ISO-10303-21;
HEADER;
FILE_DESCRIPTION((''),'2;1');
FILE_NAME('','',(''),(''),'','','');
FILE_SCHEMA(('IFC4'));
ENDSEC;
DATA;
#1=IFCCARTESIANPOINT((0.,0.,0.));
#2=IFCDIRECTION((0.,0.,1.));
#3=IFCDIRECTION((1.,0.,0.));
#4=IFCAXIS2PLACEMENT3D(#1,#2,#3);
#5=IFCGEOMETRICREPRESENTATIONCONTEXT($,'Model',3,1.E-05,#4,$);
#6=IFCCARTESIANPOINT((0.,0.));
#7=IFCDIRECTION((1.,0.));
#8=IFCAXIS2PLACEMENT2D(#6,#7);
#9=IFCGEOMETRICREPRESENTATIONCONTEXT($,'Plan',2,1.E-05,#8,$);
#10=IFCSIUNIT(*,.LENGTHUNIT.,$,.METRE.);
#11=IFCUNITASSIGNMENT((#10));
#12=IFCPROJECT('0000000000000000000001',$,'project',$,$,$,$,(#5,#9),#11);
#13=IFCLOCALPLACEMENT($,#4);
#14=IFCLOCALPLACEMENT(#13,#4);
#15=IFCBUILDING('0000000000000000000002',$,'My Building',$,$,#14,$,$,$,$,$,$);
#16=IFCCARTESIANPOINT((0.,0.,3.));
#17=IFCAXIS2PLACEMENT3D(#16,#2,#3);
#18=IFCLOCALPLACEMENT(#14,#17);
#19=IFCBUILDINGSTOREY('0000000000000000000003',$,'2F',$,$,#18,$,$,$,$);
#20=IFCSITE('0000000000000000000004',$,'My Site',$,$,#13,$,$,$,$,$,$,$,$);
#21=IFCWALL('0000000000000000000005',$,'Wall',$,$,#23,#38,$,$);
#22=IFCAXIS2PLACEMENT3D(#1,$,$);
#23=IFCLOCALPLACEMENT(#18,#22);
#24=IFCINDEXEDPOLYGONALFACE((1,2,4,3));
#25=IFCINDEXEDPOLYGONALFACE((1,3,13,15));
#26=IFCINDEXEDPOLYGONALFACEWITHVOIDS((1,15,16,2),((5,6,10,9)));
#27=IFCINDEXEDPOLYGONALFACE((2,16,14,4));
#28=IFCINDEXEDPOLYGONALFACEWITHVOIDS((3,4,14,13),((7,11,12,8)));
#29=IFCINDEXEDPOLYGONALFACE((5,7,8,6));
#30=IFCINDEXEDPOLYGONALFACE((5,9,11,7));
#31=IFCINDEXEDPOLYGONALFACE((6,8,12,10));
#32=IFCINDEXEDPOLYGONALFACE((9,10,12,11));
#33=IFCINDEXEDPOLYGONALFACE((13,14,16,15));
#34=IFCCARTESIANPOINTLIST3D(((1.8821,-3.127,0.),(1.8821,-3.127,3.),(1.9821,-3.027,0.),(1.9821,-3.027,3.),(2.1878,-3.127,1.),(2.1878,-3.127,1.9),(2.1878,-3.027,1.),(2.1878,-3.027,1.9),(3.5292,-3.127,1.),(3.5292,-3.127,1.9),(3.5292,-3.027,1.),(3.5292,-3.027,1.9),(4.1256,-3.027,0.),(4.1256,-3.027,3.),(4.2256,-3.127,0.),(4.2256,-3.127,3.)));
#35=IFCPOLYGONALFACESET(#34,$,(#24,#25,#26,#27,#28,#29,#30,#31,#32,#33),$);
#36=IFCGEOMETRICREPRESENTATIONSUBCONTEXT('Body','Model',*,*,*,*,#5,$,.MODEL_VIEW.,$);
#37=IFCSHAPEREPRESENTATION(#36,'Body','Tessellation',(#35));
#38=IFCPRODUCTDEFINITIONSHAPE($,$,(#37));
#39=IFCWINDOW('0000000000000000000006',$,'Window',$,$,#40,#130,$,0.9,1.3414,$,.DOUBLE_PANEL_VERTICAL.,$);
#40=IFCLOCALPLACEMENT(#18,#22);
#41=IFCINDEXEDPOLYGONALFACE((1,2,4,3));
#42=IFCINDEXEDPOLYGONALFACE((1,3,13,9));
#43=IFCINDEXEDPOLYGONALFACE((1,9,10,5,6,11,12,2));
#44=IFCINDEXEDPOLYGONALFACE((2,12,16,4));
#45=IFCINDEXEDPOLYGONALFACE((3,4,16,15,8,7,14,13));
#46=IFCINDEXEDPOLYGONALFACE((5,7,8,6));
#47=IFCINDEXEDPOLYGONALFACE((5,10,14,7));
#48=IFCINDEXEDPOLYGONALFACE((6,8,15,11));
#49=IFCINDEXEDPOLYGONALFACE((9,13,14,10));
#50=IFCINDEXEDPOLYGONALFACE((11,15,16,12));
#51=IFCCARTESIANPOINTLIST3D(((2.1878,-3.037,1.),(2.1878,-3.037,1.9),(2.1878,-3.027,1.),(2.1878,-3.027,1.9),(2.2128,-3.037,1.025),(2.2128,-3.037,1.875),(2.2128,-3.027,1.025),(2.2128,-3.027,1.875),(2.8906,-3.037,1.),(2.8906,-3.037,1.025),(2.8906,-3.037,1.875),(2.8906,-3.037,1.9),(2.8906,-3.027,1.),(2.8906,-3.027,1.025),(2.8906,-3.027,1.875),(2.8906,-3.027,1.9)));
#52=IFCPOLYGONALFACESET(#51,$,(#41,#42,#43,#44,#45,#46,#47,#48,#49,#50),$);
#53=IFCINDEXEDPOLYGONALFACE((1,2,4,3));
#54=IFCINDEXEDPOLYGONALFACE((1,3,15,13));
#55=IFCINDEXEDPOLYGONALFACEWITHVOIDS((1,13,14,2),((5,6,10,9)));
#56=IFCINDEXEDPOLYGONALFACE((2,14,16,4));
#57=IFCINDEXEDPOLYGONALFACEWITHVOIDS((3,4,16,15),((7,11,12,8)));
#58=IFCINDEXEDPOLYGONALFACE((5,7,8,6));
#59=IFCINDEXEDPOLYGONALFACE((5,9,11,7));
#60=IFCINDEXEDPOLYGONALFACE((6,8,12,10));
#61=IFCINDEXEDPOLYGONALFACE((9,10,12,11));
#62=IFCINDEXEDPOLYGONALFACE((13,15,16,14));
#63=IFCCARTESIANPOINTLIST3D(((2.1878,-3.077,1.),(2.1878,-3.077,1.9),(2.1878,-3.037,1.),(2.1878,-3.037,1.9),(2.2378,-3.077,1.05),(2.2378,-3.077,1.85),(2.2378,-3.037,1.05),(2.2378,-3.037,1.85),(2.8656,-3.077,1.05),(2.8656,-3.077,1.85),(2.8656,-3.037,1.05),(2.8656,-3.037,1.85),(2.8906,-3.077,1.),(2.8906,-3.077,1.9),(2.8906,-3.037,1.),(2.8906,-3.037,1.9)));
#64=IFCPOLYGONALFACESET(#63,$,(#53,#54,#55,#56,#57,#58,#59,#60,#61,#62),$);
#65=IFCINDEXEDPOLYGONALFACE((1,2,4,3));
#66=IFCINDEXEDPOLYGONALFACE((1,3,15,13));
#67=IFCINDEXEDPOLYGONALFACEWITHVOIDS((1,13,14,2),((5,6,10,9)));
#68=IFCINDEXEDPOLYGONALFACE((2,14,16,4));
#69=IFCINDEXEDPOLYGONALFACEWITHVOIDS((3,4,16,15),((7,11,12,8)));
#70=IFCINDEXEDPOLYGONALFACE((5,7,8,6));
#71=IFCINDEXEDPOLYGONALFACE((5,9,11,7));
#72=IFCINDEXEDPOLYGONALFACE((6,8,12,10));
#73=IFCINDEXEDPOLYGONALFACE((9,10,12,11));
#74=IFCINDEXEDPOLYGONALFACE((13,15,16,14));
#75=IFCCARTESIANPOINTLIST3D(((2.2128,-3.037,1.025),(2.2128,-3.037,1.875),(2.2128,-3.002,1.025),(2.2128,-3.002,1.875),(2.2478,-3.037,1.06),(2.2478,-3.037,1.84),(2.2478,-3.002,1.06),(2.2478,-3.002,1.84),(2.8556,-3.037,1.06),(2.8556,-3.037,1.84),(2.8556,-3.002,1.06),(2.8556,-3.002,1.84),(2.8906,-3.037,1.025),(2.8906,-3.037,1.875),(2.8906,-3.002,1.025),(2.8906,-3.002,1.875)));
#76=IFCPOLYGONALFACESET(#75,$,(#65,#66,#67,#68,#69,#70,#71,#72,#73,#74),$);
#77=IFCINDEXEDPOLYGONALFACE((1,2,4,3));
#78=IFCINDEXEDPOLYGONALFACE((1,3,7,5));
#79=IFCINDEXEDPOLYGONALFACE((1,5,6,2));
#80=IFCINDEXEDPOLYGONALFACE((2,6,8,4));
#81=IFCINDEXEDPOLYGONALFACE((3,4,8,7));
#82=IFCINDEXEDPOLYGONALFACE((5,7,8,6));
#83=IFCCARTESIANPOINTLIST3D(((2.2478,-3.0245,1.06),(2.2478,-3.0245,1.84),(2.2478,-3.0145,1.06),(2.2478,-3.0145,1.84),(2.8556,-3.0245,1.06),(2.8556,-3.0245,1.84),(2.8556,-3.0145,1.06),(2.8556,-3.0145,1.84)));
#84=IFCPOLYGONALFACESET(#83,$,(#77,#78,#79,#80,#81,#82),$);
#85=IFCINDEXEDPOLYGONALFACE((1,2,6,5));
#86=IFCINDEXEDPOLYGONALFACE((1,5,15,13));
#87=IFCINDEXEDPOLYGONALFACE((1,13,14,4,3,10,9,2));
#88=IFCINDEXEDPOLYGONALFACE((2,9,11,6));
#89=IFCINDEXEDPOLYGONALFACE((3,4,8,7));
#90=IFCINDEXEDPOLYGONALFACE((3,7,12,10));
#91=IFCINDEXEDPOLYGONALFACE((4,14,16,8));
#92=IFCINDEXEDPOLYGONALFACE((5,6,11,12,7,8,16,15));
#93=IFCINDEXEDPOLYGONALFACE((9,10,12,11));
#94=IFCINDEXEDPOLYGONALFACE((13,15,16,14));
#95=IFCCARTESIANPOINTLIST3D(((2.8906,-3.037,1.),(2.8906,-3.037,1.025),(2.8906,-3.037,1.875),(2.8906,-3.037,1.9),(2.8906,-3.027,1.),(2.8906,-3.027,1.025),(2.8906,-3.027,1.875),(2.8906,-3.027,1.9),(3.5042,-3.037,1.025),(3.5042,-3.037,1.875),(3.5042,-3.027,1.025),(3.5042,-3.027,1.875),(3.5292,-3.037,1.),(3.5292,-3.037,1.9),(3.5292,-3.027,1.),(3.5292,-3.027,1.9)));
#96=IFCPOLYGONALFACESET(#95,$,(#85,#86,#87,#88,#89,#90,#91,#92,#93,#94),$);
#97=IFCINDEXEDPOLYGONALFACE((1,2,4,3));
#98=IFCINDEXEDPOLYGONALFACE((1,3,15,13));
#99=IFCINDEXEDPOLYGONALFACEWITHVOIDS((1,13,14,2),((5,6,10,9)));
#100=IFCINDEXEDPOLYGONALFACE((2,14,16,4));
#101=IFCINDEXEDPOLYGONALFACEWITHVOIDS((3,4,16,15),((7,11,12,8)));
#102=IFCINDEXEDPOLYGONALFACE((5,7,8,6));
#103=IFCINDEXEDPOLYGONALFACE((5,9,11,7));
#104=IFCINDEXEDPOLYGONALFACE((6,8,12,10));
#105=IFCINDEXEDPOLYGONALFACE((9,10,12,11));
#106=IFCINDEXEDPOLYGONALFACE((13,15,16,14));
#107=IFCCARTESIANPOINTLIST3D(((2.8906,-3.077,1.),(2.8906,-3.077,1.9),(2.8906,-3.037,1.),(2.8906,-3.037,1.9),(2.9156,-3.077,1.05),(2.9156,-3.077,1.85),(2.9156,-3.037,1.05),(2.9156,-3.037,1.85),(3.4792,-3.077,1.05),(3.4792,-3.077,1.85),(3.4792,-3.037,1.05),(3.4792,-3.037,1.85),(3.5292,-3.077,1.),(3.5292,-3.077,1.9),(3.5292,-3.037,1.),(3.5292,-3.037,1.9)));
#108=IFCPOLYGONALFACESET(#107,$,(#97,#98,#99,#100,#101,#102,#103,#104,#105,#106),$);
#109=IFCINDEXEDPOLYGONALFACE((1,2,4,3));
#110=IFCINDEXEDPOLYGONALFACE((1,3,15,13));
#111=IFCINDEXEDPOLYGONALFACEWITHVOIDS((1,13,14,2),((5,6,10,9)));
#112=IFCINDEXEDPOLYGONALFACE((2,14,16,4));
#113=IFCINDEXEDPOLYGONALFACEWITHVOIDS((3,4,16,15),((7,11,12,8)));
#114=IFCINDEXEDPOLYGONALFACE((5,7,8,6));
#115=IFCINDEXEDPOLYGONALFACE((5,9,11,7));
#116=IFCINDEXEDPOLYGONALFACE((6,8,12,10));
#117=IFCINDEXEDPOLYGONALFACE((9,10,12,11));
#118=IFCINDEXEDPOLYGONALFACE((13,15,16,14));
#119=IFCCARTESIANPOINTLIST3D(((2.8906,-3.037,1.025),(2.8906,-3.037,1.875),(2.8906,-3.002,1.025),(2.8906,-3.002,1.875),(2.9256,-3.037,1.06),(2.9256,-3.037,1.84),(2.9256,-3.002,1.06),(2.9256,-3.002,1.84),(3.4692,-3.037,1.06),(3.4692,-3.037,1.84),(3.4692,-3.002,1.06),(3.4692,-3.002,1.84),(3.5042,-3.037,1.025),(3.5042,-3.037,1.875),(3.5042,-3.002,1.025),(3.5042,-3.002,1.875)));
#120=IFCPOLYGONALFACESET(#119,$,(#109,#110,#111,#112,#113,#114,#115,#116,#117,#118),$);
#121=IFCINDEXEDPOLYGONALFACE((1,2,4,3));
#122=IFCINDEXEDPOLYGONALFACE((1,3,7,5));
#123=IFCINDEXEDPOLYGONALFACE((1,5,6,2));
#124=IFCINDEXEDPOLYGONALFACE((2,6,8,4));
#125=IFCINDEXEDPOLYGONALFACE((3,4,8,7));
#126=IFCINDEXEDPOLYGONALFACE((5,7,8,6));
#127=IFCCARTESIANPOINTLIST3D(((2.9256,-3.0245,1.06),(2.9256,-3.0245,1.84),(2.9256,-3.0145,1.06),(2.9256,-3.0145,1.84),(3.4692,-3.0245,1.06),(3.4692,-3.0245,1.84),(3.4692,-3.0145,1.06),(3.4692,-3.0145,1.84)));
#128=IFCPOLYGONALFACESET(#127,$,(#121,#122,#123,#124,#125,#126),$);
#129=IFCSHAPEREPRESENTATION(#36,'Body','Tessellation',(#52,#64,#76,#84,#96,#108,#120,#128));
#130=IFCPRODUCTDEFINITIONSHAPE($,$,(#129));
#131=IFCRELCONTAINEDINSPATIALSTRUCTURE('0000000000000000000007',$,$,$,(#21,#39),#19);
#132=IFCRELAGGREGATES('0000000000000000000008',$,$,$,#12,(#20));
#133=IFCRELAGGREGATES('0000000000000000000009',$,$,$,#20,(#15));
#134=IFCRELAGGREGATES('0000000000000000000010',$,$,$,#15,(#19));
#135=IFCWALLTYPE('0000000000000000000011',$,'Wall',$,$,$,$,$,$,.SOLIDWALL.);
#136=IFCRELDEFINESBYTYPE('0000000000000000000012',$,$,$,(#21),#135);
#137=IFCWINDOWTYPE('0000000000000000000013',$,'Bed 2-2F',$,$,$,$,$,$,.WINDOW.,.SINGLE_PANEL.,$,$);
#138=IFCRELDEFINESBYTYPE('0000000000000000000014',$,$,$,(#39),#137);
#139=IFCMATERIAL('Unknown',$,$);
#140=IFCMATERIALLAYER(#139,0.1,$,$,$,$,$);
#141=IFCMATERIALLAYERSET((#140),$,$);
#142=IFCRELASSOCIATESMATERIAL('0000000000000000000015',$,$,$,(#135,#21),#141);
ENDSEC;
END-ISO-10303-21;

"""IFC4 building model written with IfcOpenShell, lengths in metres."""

from ifc_helpers import new_model, entity, si_unit, frame, origin_with_axes, origin_2d_with_axis, place, context, subcontext, project, spatial, line, indexed_curve, outline, extrude, shape, source, transform, mapped, material, layer, layer_set, layer_usage, type_object, type_shapes, element, fill, save


model = new_model("IFC4")

# Units and contexts
model_context = context("Model", 3, precision=1e-05, world=origin_with_axes())
plan_context = context("Plan", 2, precision=1e-05, world=origin_2d_with_axis())
body_context_1 = subcontext(model_context, "Body", "Model", "MODEL_VIEW")
body_context_2 = subcontext(plan_context, "Body", "Plan", "PLAN_VIEW")
ifc_project = project(units=[si_unit("LENGTHUNIT", "METRE")], contexts=[model_context, plan_context])

# Site, building, storey
site_placement = place(None, origin_with_axes())
site = spatial("IfcSite", under=ifc_project, at=site_placement, Name="My Site")
building_placement = place(site_placement, origin_with_axes())
building = spatial("IfcBuilding", under=site, at=building_placement, Name="My Building")
storey_placement = place(building_placement, frame((0.0, 0.0, 3.0), z_axis=(0.0, 0.0, 1.0), x_axis=(1.0, 0.0, 0.0)))
storey = spatial("IfcBuildingStorey", under=building, at=storey_placement, Name="2F")

# Shared definitions
ifc_material = material(Name="Unknown")

# Shared definitions
ifc_layer = layer(ifc_material, 0.1)
ifc_layer_set = layer_set([ifc_layer])
wall_type = type_object("IfcWallType", Name="Wall", PredefinedType="SOLIDWALL", material=ifc_layer_set)

# Wall, opening, window
ifc_layer_usage_1 = layer_usage(ifc_layer_set, "AXIS2", "POSITIVE", 0.0)
wall_1_placement = place(storey_placement, frame((1.8821, -3.127, 0.0), z_axis=(0.0, 0.0, 1.0), x_axis=(1.0, 0.0, 0.0)))
wall_1 = element("IfcWall", 1, at=wall_1_placement, inside=storey, type_object=wall_type, material=ifc_layer_usage_1, Name="Wall", context=body_context_1, shape_type="SweptSolid", body=[
    extrude(outline(indexed_curve([(0.0, 0.0), (0.1, 0.1), (2.2435, 0.1), (2.3435, 0.0)], segments=[line(1, 2, 3, 4, 1)])), origin_with_axes(), (0.0, 0.0, 1.0), 3.0),
])
shared_shape_1 = source(origin_with_axes(), body_context_1, "Body", "SweptSolid", [
    extrude(outline(indexed_curve([(0.0, 0.0), (1.3414, 0.0), (1.3414, 0.9), (0.0, 0.9)], segments=[line(1, 2, 3, 4, 1)])), frame((0.0, -0.6, 0.0), z_axis=(0.0, -1.0, 0.0), x_axis=(1.0, 0.0, 0.0)), (0.0, 0.0, -1.0), 1.2),
])
opening_1_placement = place(wall_1_placement, frame((0.3057, 0.0, 1.0), z_axis=(0.0, 0.0, 1.0), x_axis=(1.0, 0.0, 0.0)))
opening_1 = element("IfcOpeningElement", 2, at=opening_1_placement, cuts=wall_1, PredefinedType="OPENING", context=body_context_1, shape_type="MappedRepresentation", body=[
    mapped(shared_shape_1, transform((0.0, 0.0, 0.0), x_axis=(1.0, 0.0, 0.0), y_axis=(0.0, 1.0, 0.0), z_axis=(0.0, 0.0, 1.0), scale=1.0)),
])
window_type = type_object("IfcWindowType", Name="Bed 2-2F", PartitioningType="SINGLE_PANEL", PredefinedType="WINDOW")
shared_shape_2 = source(origin_with_axes(), body_context_1, "Body", "SweptSolid", [
    extrude(outline(indexed_curve([(0.7028, 0.0), (0.0, 0.0), (0.0, 0.9), (0.7028, 0.9), (0.7028, 0.875), (0.025, 0.875), (0.025, 0.025), (0.7028, 0.025)], segments=[line(1, 2, 3, 4, 5, 6, 7, 8, 1)])), frame((0.0, 0.09, 0.0), z_axis=(0.0, -1.0, 0.0), x_axis=(1.0, 0.0, 0.0)), (0.0, 0.0, -1.0), 0.01),
    extrude(outline(indexed_curve([(0.0, 0.0), (0.7028, 0.0), (0.7028, 0.9), (0.0, 0.9)], segments=[line(1, 2, 3, 4, 1)]), holes=[indexed_curve([(0.05, 0.05), (0.6778, 0.05), (0.6778, 0.85), (0.05, 0.85)], segments=[line(1, 2, 3, 4, 1)])]), frame((0.0, 0.05, 0.0), z_axis=(0.0, -1.0, 0.0), x_axis=(1.0, 0.0, 0.0)), (0.0, 0.0, -1.0), 0.04),
    extrude(outline(indexed_curve([(0.0, 0.0), (0.6778, 0.0), (0.6778, 0.85), (0.0, 0.85)], segments=[line(1, 2, 3, 4, 1)]), holes=[indexed_curve([(0.035, 0.035), (0.6428, 0.035), (0.6428, 0.815), (0.035, 0.815)], segments=[line(1, 2, 3, 4, 1)])]), frame((0.025, 0.09, 0.025), z_axis=(0.0, -1.0, 0.0), x_axis=(1.0, 0.0, 0.0)), (0.0, 0.0, -1.0), 0.035),
    extrude(outline(indexed_curve([(0.035, 0.035), (0.6428, 0.035), (0.6428, 0.815), (0.035, 0.815)], segments=[line(1, 2, 3, 4, 1)])), frame((0.025, 0.1025, 0.025), z_axis=(0.0, -1.0, 0.0), x_axis=(1.0, 0.0, 0.0)), (0.0, 0.0, -1.0), 0.01),
    extrude(outline(indexed_curve([(0.0, 0.9), (0.6386, 0.9), (0.6386, 0.0), (0.0, 0.0), (0.0, 0.025), (0.6136, 0.025), (0.6136, 0.875), (0.0, 0.875)], segments=[line(1, 2, 3, 4, 5, 6, 7, 8, 1)])), frame((0.7028, 0.09, 0.0), z_axis=(0.0, -1.0, 0.0), x_axis=(1.0, 0.0, 0.0)), (0.0, 0.0, -1.0), 0.01),
    extrude(outline(indexed_curve([(0.0, 0.0), (0.6386, 0.0), (0.6386, 0.9), (0.0, 0.9)], segments=[line(1, 2, 3, 4, 1)]), holes=[indexed_curve([(0.025, 0.05), (0.5886, 0.05), (0.5886, 0.85), (0.025, 0.85)], segments=[line(1, 2, 3, 4, 1)])]), frame((0.7028, 0.05, 0.0), z_axis=(0.0, -1.0, 0.0), x_axis=(1.0, 0.0, 0.0)), (0.0, 0.0, -1.0), 0.04),
    extrude(outline(indexed_curve([(0.0, 0.0), (0.6136, 0.0), (0.6136, 0.85), (0.0, 0.85)], segments=[line(1, 2, 3, 4, 1)]), holes=[indexed_curve([(0.035, 0.035), (0.5786, 0.035), (0.5786, 0.815), (0.035, 0.815)], segments=[line(1, 2, 3, 4, 1)])]), frame((0.7028, 0.09, 0.025), z_axis=(0.0, -1.0, 0.0), x_axis=(1.0, 0.0, 0.0)), (0.0, 0.0, -1.0), 0.035),
    extrude(outline(indexed_curve([(0.035, 0.035), (0.5786, 0.035), (0.5786, 0.815), (0.035, 0.815)], segments=[line(1, 2, 3, 4, 1)])), frame((0.7028, 0.1025, 0.025), z_axis=(0.0, -1.0, 0.0), x_axis=(1.0, 0.0, 0.0)), (0.0, 0.0, -1.0), 0.01),
])
shared_shape_3 = source(origin_with_axes(), body_context_2, "Body", "Curve2D", [
    entity("IfcIndexedPolyCurve", entity("IfcCartesianPointList2D", [[0.05, 0.05], [0.6778, 0.05]])),
    entity("IfcIndexedPolyCurve", entity("IfcCartesianPointList2D", [[0.0, 0.1], [0.025, 0.1], [0.025, 0.09], [0.05, 0.09], [0.05, 0.05], [0.0, 0.05]]), [entity("IfcLineIndex", [1, 2, 3, 4, 5, 6, 1])]),
    entity("IfcIndexedPolyCurve", entity("IfcCartesianPointList2D", [[0.7028, 0.1], [0.7028, 0.1], [0.7028, 0.09], [0.6778, 0.09], [0.6778, 0.05], [0.7028, 0.05]])),
    entity("IfcIndexedPolyCurve", entity("IfcCartesianPointList2D", [[0.025, 0.09], [0.06, 0.09], [0.06, 0.125], [0.025, 0.125]]), [entity("IfcLineIndex", [1, 2, 3, 4, 1])]),
    entity("IfcIndexedPolyCurve", entity("IfcCartesianPointList2D", [[0.7028, 0.09], [0.6678, 0.09], [0.6678, 0.125], [0.7028, 0.125]]), [entity("IfcLineIndex", [1, 2, 3, 4, 1])]),
    entity("IfcIndexedPolyCurve", entity("IfcCartesianPointList2D", [[0.06, 0.09], [0.6678, 0.09]])),
    entity("IfcIndexedPolyCurve", entity("IfcCartesianPointList2D", [[0.06, 0.125], [0.6678, 0.125]])),
    entity("IfcIndexedPolyCurve", entity("IfcCartesianPointList2D", [[0.06, 0.1075], [0.6678, 0.1075]])),
    entity("IfcIndexedPolyCurve", entity("IfcCartesianPointList2D", [[0.7278, 0.05], [1.2914, 0.05]])),
    entity("IfcIndexedPolyCurve", entity("IfcCartesianPointList2D", [[0.7028, 0.1], [0.7028, 0.1], [0.7028, 0.09], [0.7278, 0.09], [0.7278, 0.05], [0.7028, 0.05]])),
    entity("IfcIndexedPolyCurve", entity("IfcCartesianPointList2D", [[1.3414, 0.1], [1.3164, 0.1], [1.3164, 0.09], [1.2914, 0.09], [1.2914, 0.05], [1.3414, 0.05]]), [entity("IfcLineIndex", [1, 2, 3, 4, 5, 6, 1])]),
    entity("IfcIndexedPolyCurve", entity("IfcCartesianPointList2D", [[0.7028, 0.09], [0.7378, 0.09], [0.7378, 0.125], [0.7028, 0.125]]), [entity("IfcLineIndex", [1, 2, 3, 4, 1])]),
    entity("IfcIndexedPolyCurve", entity("IfcCartesianPointList2D", [[1.3164, 0.09], [1.2814, 0.09], [1.2814, 0.125], [1.3164, 0.125]]), [entity("IfcLineIndex", [1, 2, 3, 4, 1])]),
    entity("IfcIndexedPolyCurve", entity("IfcCartesianPointList2D", [[0.7378, 0.09], [1.2814, 0.09]])),
    entity("IfcIndexedPolyCurve", entity("IfcCartesianPointList2D", [[0.7378, 0.125], [1.2814, 0.125]])),
    entity("IfcIndexedPolyCurve", entity("IfcCartesianPointList2D", [[0.7378, 0.1075], [1.2814, 0.1075]])),
])
type_shapes(window_type, [shared_shape_2, shared_shape_3])
window_placement = place(opening_1_placement, origin_with_axes())
window = element("IfcWindow", 3, at=window_placement, inside=storey, type_object=window_type, Name="Window", OverallHeight=0.9, OverallWidth=1.3414, PartitioningType="DOUBLE_PANEL_VERTICAL", shapes=[
    shape(body_context_1, "Body", "MappedRepresentation", [mapped(shared_shape_2, transform((0.0, 0.0, 0.0), x_axis=(1.0, 0.0, 0.0), y_axis=(0.0, 1.0, 0.0), z_axis=(0.0, 0.0, 1.0), scale=1.0))]),
    shape(body_context_2, "Body", "MappedRepresentation", [mapped(shared_shape_3, transform((0.0, 0.0, 0.0), x_axis=(1.0, 0.0, 0.0), y_axis=(0.0, 1.0, 0.0), z_axis=(0.0, 0.0, 1.0), scale=1.0))]),
])
fill(opening_1, window)

save(model, "model.ifc")
